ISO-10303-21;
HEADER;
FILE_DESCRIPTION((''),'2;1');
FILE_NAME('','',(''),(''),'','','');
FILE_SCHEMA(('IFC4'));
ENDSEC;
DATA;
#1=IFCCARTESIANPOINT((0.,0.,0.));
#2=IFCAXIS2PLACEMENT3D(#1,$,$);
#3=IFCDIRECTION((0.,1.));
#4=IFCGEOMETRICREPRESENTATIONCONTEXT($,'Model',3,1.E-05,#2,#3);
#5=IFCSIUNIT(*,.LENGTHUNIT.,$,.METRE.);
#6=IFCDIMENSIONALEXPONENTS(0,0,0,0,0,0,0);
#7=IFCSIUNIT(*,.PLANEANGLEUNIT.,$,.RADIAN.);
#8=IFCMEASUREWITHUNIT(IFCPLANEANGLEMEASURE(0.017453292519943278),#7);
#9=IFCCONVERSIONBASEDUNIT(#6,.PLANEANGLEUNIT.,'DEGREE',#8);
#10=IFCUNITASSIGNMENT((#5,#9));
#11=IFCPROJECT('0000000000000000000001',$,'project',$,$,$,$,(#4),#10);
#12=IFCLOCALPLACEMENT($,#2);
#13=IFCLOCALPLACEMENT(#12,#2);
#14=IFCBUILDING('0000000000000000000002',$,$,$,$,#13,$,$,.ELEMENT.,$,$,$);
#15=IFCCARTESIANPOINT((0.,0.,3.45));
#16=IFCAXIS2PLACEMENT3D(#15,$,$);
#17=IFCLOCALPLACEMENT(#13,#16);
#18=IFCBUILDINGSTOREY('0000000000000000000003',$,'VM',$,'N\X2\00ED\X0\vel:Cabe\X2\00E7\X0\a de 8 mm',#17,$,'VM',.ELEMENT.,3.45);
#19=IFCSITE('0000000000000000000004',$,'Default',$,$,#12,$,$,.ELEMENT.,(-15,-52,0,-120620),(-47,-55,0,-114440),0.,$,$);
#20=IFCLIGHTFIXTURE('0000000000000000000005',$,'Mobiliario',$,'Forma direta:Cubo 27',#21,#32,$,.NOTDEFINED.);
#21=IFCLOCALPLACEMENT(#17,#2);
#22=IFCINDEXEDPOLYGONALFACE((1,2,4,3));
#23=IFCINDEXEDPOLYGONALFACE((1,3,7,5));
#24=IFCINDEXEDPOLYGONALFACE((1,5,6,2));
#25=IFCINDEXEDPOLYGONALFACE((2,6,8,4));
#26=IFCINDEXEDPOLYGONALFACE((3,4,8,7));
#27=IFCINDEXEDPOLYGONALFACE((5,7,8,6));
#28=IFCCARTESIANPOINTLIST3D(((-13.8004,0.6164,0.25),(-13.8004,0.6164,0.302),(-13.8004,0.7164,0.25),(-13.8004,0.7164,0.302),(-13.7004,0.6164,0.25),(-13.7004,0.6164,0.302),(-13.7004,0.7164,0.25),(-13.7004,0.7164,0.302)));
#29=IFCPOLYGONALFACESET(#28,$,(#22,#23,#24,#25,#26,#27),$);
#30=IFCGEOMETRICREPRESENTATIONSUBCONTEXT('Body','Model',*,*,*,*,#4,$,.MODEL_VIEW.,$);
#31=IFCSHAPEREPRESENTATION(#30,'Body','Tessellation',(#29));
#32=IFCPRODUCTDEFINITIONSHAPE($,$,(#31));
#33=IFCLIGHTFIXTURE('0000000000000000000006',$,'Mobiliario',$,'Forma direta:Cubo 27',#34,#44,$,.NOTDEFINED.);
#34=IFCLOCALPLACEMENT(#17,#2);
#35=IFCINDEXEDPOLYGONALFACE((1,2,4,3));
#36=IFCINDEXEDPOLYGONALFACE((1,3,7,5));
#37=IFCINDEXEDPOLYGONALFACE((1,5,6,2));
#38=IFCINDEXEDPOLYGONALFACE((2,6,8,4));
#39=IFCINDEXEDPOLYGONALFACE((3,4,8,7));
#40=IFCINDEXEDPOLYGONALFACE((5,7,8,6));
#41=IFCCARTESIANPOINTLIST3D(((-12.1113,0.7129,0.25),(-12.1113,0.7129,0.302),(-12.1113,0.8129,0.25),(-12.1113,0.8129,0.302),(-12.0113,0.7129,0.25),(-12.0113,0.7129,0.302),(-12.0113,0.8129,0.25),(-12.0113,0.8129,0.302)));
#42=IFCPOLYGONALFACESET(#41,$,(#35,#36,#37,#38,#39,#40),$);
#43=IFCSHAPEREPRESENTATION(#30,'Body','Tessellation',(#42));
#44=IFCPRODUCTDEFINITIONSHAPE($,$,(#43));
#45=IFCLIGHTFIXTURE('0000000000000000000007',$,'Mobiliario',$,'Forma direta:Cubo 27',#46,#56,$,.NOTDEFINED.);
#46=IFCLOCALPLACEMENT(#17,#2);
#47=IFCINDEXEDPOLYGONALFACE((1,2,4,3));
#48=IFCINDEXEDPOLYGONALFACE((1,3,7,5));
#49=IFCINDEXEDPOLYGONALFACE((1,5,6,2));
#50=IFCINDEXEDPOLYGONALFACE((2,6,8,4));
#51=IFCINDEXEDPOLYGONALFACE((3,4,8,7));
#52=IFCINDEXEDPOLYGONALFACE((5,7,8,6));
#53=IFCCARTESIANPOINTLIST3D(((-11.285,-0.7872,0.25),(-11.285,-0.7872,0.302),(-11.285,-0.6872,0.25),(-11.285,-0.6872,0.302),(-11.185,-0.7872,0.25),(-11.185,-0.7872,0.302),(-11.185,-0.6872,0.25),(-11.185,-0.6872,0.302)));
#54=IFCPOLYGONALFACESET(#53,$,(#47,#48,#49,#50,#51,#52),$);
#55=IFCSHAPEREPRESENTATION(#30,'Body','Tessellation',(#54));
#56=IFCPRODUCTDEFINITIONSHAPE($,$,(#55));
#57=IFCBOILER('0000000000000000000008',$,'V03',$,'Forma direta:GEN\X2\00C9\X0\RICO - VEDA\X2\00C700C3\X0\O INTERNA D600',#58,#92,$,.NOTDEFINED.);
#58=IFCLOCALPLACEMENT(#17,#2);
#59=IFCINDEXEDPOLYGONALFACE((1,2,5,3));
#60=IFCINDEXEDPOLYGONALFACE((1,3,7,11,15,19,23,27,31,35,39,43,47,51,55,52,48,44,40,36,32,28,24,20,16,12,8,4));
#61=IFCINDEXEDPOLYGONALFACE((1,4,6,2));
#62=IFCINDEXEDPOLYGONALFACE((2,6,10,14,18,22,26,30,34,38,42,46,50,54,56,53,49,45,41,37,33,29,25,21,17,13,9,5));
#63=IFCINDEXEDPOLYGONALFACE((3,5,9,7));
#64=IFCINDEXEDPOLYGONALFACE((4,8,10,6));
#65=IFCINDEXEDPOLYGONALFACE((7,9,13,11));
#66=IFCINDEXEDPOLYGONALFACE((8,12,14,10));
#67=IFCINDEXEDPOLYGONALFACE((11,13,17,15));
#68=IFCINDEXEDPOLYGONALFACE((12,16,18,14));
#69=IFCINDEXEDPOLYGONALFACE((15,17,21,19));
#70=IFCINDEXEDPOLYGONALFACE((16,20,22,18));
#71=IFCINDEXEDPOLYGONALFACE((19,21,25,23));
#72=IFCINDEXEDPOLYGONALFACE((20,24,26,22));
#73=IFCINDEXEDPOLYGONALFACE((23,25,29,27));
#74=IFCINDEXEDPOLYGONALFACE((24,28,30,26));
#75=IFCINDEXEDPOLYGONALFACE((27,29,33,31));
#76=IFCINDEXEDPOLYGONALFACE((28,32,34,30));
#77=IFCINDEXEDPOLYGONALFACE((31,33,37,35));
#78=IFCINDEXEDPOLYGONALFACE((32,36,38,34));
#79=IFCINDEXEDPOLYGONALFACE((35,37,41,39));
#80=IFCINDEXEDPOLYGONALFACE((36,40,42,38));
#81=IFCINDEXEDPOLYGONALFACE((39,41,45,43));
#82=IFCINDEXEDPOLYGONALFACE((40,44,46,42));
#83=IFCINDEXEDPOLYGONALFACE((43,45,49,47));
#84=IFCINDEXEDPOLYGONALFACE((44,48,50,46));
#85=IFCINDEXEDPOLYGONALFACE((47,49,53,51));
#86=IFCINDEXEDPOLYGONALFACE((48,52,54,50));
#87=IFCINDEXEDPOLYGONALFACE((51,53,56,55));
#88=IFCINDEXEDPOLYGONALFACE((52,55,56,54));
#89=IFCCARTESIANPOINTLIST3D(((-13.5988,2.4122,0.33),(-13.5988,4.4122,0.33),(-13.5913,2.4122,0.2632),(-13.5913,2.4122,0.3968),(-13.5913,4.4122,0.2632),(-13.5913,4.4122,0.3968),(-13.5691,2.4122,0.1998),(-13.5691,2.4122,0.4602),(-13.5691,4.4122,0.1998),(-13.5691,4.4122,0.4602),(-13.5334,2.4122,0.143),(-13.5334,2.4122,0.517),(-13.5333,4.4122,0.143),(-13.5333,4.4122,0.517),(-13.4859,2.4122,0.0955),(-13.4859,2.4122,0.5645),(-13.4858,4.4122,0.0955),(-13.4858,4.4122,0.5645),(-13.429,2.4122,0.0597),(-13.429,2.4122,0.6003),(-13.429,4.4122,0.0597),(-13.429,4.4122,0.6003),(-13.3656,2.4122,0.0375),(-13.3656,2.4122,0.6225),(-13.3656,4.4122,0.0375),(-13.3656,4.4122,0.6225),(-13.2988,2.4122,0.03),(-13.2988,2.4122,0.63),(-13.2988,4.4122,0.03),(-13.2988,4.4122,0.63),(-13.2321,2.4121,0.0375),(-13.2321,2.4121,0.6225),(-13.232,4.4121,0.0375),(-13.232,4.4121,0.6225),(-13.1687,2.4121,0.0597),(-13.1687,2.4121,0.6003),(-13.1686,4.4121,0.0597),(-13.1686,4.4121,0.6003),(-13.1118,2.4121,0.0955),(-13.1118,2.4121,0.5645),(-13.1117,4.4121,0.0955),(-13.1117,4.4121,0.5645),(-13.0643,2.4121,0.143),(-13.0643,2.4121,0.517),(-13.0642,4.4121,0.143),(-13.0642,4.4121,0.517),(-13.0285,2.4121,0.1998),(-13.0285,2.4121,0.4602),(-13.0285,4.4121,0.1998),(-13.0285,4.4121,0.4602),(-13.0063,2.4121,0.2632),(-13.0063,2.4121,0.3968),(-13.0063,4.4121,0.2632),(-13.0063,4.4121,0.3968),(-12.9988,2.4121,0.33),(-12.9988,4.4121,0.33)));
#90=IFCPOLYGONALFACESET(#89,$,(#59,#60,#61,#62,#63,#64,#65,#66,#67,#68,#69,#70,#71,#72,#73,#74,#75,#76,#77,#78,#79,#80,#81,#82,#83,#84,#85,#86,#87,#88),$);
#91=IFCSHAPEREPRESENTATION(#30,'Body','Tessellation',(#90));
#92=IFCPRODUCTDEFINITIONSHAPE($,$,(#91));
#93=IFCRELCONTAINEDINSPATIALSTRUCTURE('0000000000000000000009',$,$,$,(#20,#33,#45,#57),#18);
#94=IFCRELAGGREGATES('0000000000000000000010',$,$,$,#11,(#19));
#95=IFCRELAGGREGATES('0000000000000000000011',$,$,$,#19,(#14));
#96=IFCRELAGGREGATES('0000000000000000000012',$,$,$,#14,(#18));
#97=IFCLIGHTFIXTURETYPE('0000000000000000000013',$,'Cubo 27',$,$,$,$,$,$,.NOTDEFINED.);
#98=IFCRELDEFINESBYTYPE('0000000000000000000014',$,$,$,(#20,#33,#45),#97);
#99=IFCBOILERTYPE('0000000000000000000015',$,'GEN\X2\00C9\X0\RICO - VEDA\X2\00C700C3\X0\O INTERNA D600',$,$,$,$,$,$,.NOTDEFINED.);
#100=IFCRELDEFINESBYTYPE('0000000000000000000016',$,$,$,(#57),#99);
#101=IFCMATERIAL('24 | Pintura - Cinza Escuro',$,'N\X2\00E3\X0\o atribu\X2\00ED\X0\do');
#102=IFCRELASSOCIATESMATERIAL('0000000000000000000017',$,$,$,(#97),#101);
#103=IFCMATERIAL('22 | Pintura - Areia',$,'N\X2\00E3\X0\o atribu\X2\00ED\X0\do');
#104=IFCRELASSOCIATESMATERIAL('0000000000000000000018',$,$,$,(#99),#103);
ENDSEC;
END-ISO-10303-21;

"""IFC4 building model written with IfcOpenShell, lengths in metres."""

from ifc_helpers import new_model, entity, si_unit, converted_unit, direction, frame, origin, place, context, subcontext, project, spatial, arc, indexed_curve, outline, extrude, material, type_object, element, save


model = new_model("IFC4")

# Units and contexts
model_context = context("Model", 3, precision=1e-05, world=origin(), true_north=direction((0.0, 1.0)))
body_context = subcontext(model_context, "Body", "Model", "MODEL_VIEW")
ifc_project = project(units=[si_unit("LENGTHUNIT", "METRE"), converted_unit("PLANEANGLEUNIT", "DEGREE", entity("IfcPlaneAngleMeasure", 0.017453292519943278), si_unit("PLANEANGLEUNIT", "RADIAN"), dimensions=[0, 0, 0, 0, 0, 0, 0])], contexts=[model_context])

# Site, building, storey
site_placement = place(None, origin())
site = spatial("IfcSite", under=ifc_project, at=site_placement, Name="Default", CompositionType="ELEMENT", RefLatitude=(-15, -52, 0, -120620), RefLongitude=(-47, -55, 0, -114440), RefElevation=0.0)
building_placement = place(site_placement, origin())
building = spatial("IfcBuilding", under=site, at=building_placement, CompositionType="ELEMENT")
storey_placement = place(building_placement, frame((0.0, 0.0, 3.45)))
storey = spatial("IfcBuildingStorey", under=building, at=storey_placement, Name="VM", ObjectType="Nível:Cabeça de 8 mm", LongName="VM", CompositionType="ELEMENT", Elevation=3.45)

# Shared definitions
ifc_material_1 = material(Name="22 | Pintura - Areia", Category="Não atribuído")

# Light fixtures
ifc_material_2 = material(Name="24 | Pintura - Cinza Escuro", Category="Não atribuído")
light_fixture_type_1 = type_object("IfcLightFixtureType", Name="Cubo 27", PredefinedType="NOTDEFINED", material=ifc_material_2)
light_fixture_1_placement = place(storey_placement, origin())
element("IfcLightFixture", 1, at=light_fixture_1_placement, inside=storey, type_object=light_fixture_type_1, Name="Mobiliario", ObjectType="Forma direta:Cubo 27", PredefinedType="NOTDEFINED", context=body_context, shape_type="SweptSolid", body=[
    extrude(outline(indexed_curve([(-0.05, -0.05), (0.05, -0.05), (0.05, 0.05), (-0.05, 0.05), (-0.05, -0.05)], self_intersect=False)), frame((-13.7504, 0.6664, 0.25), z_axis=(0.0, 0.0, 1.0), x_axis=(-0.000013, -1.0, 0.0)), (0.0, 0.0, 1.0), 0.052),
])
light_fixture_2_placement = place(storey_placement, origin())
element("IfcLightFixture", 2, at=light_fixture_2_placement, inside=storey, type_object=light_fixture_type_1, Name="Mobiliario", ObjectType="Forma direta:Cubo 27", PredefinedType="NOTDEFINED", context=body_context, shape_type="SweptSolid", body=[
    extrude(outline(indexed_curve([(-0.05, -0.05), (0.05, -0.05), (0.05, 0.05), (-0.05, 0.05), (-0.05, -0.05)], self_intersect=False)), frame((-12.0613, 0.7629, 0.25), z_axis=(0.0, 0.0, 1.0), x_axis=(-0.000013, -1.0, 0.0)), (0.0, 0.0, 1.0), 0.052),
])
light_fixture_3_placement = place(storey_placement, origin())
element("IfcLightFixture", 3, at=light_fixture_3_placement, inside=storey, type_object=light_fixture_type_1, Name="Mobiliario", ObjectType="Forma direta:Cubo 27", PredefinedType="NOTDEFINED", context=body_context, shape_type="SweptSolid", body=[
    extrude(outline(indexed_curve([(-0.05, -0.05), (0.05, -0.05), (0.05, 0.05), (-0.05, 0.05), (-0.05, -0.05)], self_intersect=False)), frame((-11.235, -0.7372, 0.25), z_axis=(0.0, 0.0, 1.0), x_axis=(-0.000013, -1.0, 0.0)), (0.0, 0.0, 1.0), 0.052),
])

# Boiler
boiler_type = type_object("IfcBoilerType", Name="GENÉRICO - VEDAÇÃO INTERNA D600", PredefinedType="NOTDEFINED", material=ifc_material_1)
boiler_placement = place(storey_placement, origin())
element("IfcBoiler", 4, at=boiler_placement, inside=storey, type_object=boiler_type, Name="V03", ObjectType="Forma direta:GENÉRICO - VEDAÇÃO INTERNA D600", PredefinedType="NOTDEFINED", context=body_context, shape_type="SweptSolid", body=[
    extrude(outline(indexed_curve([(-0.3, 0.0), (0.0, -0.3), (0.3, 0.0), (0.0, 0.3)], segments=[arc(1, 2, 3), arc(3, 4, 1)], self_intersect=False)), frame((-13.2988, 2.4122, 0.33), z_axis=(0.000013, 1.0, 0.0), x_axis=(0.0, 0.0, 1.0)), (0.0, 0.0, 1.0), 2.0),
])

save(model, "model.ifc")
